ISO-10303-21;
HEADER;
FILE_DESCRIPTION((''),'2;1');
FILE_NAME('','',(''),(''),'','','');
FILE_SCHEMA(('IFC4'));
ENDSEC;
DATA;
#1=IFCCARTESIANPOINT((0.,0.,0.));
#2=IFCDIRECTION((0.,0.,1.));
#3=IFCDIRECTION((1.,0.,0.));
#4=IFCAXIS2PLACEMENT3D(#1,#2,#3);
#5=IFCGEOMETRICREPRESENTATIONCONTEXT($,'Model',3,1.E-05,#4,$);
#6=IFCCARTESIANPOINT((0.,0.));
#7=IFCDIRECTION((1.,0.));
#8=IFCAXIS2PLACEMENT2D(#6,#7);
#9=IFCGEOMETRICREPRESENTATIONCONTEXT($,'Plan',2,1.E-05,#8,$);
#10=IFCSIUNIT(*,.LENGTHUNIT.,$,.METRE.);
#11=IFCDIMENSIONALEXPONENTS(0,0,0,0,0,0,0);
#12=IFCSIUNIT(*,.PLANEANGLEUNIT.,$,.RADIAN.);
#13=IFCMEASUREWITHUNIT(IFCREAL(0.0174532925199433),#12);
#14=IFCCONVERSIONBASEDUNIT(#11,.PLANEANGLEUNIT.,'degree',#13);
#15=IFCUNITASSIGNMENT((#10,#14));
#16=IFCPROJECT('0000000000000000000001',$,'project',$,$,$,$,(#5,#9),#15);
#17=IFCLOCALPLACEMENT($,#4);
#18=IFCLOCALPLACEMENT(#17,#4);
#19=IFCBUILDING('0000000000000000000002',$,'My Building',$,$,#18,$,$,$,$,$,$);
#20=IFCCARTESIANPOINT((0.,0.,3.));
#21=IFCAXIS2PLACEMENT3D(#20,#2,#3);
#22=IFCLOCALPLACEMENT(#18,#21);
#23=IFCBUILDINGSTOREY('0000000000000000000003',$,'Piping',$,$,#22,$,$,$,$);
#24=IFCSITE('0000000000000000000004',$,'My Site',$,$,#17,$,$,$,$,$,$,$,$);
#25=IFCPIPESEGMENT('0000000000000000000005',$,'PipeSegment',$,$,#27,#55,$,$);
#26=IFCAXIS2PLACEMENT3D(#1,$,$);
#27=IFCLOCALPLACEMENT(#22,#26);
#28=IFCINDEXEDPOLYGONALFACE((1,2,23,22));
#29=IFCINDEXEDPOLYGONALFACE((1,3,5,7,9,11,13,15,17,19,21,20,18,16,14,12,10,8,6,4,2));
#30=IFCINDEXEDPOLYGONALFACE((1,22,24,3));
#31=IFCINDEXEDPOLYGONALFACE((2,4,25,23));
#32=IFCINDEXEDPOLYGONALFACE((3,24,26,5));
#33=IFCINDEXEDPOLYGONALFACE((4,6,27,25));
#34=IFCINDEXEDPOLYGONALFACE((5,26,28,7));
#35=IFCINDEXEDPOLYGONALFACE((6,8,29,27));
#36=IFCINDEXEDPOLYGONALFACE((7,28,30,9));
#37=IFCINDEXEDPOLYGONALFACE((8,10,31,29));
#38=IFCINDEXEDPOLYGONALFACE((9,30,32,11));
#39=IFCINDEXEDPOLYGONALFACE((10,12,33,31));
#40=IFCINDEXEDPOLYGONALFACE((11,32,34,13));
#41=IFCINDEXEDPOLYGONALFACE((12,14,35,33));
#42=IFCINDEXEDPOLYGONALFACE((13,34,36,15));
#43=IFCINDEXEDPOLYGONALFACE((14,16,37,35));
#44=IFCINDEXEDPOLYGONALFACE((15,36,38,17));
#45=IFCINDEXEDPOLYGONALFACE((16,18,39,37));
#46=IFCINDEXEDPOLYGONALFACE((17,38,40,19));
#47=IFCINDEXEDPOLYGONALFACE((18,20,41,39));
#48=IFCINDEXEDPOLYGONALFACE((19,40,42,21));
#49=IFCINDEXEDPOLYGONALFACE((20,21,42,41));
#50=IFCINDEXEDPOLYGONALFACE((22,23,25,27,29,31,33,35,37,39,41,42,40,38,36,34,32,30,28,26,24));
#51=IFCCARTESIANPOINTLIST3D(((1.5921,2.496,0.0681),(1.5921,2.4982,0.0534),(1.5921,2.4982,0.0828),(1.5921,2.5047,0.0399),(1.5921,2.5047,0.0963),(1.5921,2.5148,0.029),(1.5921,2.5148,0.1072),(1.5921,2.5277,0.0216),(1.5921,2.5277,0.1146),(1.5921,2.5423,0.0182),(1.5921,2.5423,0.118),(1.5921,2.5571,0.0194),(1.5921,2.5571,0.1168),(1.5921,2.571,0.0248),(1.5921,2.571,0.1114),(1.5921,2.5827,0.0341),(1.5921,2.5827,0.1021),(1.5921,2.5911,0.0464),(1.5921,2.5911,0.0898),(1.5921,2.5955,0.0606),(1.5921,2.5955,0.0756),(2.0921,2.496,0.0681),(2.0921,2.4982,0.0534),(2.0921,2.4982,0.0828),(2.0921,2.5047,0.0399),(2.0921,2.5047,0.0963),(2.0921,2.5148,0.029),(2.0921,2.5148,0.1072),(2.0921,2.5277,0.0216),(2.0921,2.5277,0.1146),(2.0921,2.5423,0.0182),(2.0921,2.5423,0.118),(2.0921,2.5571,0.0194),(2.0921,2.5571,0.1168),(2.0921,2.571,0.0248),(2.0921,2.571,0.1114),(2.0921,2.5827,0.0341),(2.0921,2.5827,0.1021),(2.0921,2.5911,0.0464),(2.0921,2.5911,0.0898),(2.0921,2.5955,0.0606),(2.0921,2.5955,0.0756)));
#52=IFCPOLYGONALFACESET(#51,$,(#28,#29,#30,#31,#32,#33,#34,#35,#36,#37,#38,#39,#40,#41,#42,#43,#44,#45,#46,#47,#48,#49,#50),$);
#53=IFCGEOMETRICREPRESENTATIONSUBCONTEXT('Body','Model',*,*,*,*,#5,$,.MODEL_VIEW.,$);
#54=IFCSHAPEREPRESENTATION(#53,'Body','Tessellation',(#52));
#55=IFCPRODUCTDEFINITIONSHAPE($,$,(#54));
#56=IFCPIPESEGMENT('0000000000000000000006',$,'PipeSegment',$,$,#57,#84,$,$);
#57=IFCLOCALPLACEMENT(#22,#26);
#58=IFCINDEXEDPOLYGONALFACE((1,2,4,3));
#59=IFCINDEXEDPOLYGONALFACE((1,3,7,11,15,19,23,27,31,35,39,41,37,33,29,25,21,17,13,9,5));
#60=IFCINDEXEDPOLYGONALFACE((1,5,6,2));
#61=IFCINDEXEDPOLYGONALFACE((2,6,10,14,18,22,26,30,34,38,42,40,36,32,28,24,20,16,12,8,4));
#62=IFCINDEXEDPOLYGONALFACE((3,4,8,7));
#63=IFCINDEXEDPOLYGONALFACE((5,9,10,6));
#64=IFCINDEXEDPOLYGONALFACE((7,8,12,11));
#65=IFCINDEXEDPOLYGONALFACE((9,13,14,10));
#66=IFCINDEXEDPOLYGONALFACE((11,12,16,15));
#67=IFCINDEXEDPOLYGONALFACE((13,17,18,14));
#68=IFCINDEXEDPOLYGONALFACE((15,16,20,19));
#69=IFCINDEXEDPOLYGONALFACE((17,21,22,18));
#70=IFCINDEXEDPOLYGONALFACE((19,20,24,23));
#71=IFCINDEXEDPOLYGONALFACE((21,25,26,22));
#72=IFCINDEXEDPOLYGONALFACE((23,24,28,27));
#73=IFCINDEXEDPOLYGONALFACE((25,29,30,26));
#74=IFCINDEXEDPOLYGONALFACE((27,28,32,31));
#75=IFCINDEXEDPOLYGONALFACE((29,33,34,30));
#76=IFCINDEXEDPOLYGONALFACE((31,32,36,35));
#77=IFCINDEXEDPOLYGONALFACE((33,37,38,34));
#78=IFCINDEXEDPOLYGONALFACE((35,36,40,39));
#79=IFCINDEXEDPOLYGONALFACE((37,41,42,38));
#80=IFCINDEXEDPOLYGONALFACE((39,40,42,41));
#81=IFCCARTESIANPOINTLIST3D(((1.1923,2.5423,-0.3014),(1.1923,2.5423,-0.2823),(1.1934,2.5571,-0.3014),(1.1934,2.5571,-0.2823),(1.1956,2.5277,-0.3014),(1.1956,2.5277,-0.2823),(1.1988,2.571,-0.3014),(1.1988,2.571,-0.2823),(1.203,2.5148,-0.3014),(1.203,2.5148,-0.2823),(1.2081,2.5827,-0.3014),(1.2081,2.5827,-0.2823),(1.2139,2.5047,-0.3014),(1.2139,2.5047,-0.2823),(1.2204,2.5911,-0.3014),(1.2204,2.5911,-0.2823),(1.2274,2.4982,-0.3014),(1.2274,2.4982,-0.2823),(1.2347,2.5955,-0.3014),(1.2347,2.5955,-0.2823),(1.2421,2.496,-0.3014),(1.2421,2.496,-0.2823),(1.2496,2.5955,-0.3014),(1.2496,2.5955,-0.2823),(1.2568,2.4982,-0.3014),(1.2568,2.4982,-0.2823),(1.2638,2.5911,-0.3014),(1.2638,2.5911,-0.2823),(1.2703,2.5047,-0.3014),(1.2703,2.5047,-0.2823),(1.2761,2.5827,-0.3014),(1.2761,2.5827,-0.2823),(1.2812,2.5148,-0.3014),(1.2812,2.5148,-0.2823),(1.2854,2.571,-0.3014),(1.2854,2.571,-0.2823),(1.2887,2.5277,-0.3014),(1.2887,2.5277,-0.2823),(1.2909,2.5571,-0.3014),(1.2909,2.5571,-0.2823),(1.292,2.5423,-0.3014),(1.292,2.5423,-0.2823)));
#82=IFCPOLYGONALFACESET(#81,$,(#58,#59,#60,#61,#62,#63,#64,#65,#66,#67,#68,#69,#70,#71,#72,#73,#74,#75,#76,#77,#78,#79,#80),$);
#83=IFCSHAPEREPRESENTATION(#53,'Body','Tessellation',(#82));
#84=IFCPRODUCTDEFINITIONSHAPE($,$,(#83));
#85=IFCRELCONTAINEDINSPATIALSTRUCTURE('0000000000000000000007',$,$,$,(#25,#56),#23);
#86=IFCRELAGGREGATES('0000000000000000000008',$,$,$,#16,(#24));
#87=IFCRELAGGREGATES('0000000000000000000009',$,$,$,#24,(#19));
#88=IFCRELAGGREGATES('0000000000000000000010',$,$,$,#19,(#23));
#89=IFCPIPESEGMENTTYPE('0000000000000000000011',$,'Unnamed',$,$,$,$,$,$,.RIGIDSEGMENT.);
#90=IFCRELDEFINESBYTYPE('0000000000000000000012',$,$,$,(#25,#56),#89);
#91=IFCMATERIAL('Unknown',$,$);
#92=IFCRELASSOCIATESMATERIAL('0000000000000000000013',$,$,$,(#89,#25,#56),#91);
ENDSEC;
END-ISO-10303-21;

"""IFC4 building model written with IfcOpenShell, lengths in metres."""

from ifc_helpers import new_model, entity, si_unit, converted_unit, frame, origin_with_axes, origin_2d_with_axis, place, context, subcontext, project, spatial, circle, extrude, material, material_profile, profile_set, profile_usage, type_object, element, save


model = new_model("IFC4")

# Units and contexts
model_context = context("Model", 3, precision=1e-05, world=origin_with_axes())
plan_context = context("Plan", 2, precision=1e-05, world=origin_2d_with_axis())
body_context = subcontext(model_context, "Body", "Model", "MODEL_VIEW")
ifc_project = project(units=[si_unit("LENGTHUNIT", "METRE"), converted_unit("PLANEANGLEUNIT", "degree", entity("IfcReal", 0.0174532925199433), si_unit("PLANEANGLEUNIT", "RADIAN"), dimensions=[0, 0, 0, 0, 0, 0, 0])], contexts=[model_context, plan_context])

# Site, building, storey
site_placement = place(None, origin_with_axes())
site = spatial("IfcSite", under=ifc_project, at=site_placement, Name="My Site")
building_placement = place(site_placement, origin_with_axes())
building = spatial("IfcBuilding", under=site, at=building_placement, Name="My Building")
storey_placement = place(building_placement, frame((0.0, 0.0, 3.0), z_axis=(0.0, 0.0, 1.0), x_axis=(1.0, 0.0, 0.0)))
storey = spatial("IfcBuildingStorey", under=building, at=storey_placement, Name="Piping")

# Pipe segments
ifc_material = material(Name="Unknown")
ifc_material_profile_1 = material_profile(ifc_material, circle(Radius=0.05))
ifc_profile_set_1 = profile_set([ifc_material_profile_1])
pipe_segment_type = type_object("IfcPipeSegmentType", Name="Unnamed", PredefinedType="RIGIDSEGMENT", material=ifc_profile_set_1)
ifc_profile_usage_1 = profile_usage(ifc_profile_set_1, cardinal=5)
pipe_segment_1_placement = place(storey_placement, frame((2.0921, 2.546, 0.0681), z_axis=(-1.0, 0.0, 0.0), x_axis=(0.0, -1.0, 0.0)))
element("IfcPipeSegment", 1, at=pipe_segment_1_placement, inside=storey, type_object=pipe_segment_type, material=ifc_profile_usage_1, Name="PipeSegment", context=body_context, shape_type="SweptSolid", body=[
    extrude(circle(Radius=0.05), origin_with_axes(), (0.0, 0.0, 1.0), 0.5),
])
ifc_profile_usage_2 = profile_usage(ifc_profile_set_1, cardinal=5)
pipe_segment_2_placement = place(storey_placement, frame((1.2421, 2.546, -0.2823), z_axis=(0.0, 0.0, -1.0), x_axis=(0.0, -1.0, 0.0)))
element("IfcPipeSegment", 2, at=pipe_segment_2_placement, inside=storey, type_object=pipe_segment_type, material=ifc_profile_usage_2, Name="PipeSegment", context=body_context, shape_type="SweptSolid", body=[
    extrude(circle(Radius=0.05), origin_with_axes(), (0.0, 0.0, 1.0), 0.0191),
])

save(model, "model.ifc")
